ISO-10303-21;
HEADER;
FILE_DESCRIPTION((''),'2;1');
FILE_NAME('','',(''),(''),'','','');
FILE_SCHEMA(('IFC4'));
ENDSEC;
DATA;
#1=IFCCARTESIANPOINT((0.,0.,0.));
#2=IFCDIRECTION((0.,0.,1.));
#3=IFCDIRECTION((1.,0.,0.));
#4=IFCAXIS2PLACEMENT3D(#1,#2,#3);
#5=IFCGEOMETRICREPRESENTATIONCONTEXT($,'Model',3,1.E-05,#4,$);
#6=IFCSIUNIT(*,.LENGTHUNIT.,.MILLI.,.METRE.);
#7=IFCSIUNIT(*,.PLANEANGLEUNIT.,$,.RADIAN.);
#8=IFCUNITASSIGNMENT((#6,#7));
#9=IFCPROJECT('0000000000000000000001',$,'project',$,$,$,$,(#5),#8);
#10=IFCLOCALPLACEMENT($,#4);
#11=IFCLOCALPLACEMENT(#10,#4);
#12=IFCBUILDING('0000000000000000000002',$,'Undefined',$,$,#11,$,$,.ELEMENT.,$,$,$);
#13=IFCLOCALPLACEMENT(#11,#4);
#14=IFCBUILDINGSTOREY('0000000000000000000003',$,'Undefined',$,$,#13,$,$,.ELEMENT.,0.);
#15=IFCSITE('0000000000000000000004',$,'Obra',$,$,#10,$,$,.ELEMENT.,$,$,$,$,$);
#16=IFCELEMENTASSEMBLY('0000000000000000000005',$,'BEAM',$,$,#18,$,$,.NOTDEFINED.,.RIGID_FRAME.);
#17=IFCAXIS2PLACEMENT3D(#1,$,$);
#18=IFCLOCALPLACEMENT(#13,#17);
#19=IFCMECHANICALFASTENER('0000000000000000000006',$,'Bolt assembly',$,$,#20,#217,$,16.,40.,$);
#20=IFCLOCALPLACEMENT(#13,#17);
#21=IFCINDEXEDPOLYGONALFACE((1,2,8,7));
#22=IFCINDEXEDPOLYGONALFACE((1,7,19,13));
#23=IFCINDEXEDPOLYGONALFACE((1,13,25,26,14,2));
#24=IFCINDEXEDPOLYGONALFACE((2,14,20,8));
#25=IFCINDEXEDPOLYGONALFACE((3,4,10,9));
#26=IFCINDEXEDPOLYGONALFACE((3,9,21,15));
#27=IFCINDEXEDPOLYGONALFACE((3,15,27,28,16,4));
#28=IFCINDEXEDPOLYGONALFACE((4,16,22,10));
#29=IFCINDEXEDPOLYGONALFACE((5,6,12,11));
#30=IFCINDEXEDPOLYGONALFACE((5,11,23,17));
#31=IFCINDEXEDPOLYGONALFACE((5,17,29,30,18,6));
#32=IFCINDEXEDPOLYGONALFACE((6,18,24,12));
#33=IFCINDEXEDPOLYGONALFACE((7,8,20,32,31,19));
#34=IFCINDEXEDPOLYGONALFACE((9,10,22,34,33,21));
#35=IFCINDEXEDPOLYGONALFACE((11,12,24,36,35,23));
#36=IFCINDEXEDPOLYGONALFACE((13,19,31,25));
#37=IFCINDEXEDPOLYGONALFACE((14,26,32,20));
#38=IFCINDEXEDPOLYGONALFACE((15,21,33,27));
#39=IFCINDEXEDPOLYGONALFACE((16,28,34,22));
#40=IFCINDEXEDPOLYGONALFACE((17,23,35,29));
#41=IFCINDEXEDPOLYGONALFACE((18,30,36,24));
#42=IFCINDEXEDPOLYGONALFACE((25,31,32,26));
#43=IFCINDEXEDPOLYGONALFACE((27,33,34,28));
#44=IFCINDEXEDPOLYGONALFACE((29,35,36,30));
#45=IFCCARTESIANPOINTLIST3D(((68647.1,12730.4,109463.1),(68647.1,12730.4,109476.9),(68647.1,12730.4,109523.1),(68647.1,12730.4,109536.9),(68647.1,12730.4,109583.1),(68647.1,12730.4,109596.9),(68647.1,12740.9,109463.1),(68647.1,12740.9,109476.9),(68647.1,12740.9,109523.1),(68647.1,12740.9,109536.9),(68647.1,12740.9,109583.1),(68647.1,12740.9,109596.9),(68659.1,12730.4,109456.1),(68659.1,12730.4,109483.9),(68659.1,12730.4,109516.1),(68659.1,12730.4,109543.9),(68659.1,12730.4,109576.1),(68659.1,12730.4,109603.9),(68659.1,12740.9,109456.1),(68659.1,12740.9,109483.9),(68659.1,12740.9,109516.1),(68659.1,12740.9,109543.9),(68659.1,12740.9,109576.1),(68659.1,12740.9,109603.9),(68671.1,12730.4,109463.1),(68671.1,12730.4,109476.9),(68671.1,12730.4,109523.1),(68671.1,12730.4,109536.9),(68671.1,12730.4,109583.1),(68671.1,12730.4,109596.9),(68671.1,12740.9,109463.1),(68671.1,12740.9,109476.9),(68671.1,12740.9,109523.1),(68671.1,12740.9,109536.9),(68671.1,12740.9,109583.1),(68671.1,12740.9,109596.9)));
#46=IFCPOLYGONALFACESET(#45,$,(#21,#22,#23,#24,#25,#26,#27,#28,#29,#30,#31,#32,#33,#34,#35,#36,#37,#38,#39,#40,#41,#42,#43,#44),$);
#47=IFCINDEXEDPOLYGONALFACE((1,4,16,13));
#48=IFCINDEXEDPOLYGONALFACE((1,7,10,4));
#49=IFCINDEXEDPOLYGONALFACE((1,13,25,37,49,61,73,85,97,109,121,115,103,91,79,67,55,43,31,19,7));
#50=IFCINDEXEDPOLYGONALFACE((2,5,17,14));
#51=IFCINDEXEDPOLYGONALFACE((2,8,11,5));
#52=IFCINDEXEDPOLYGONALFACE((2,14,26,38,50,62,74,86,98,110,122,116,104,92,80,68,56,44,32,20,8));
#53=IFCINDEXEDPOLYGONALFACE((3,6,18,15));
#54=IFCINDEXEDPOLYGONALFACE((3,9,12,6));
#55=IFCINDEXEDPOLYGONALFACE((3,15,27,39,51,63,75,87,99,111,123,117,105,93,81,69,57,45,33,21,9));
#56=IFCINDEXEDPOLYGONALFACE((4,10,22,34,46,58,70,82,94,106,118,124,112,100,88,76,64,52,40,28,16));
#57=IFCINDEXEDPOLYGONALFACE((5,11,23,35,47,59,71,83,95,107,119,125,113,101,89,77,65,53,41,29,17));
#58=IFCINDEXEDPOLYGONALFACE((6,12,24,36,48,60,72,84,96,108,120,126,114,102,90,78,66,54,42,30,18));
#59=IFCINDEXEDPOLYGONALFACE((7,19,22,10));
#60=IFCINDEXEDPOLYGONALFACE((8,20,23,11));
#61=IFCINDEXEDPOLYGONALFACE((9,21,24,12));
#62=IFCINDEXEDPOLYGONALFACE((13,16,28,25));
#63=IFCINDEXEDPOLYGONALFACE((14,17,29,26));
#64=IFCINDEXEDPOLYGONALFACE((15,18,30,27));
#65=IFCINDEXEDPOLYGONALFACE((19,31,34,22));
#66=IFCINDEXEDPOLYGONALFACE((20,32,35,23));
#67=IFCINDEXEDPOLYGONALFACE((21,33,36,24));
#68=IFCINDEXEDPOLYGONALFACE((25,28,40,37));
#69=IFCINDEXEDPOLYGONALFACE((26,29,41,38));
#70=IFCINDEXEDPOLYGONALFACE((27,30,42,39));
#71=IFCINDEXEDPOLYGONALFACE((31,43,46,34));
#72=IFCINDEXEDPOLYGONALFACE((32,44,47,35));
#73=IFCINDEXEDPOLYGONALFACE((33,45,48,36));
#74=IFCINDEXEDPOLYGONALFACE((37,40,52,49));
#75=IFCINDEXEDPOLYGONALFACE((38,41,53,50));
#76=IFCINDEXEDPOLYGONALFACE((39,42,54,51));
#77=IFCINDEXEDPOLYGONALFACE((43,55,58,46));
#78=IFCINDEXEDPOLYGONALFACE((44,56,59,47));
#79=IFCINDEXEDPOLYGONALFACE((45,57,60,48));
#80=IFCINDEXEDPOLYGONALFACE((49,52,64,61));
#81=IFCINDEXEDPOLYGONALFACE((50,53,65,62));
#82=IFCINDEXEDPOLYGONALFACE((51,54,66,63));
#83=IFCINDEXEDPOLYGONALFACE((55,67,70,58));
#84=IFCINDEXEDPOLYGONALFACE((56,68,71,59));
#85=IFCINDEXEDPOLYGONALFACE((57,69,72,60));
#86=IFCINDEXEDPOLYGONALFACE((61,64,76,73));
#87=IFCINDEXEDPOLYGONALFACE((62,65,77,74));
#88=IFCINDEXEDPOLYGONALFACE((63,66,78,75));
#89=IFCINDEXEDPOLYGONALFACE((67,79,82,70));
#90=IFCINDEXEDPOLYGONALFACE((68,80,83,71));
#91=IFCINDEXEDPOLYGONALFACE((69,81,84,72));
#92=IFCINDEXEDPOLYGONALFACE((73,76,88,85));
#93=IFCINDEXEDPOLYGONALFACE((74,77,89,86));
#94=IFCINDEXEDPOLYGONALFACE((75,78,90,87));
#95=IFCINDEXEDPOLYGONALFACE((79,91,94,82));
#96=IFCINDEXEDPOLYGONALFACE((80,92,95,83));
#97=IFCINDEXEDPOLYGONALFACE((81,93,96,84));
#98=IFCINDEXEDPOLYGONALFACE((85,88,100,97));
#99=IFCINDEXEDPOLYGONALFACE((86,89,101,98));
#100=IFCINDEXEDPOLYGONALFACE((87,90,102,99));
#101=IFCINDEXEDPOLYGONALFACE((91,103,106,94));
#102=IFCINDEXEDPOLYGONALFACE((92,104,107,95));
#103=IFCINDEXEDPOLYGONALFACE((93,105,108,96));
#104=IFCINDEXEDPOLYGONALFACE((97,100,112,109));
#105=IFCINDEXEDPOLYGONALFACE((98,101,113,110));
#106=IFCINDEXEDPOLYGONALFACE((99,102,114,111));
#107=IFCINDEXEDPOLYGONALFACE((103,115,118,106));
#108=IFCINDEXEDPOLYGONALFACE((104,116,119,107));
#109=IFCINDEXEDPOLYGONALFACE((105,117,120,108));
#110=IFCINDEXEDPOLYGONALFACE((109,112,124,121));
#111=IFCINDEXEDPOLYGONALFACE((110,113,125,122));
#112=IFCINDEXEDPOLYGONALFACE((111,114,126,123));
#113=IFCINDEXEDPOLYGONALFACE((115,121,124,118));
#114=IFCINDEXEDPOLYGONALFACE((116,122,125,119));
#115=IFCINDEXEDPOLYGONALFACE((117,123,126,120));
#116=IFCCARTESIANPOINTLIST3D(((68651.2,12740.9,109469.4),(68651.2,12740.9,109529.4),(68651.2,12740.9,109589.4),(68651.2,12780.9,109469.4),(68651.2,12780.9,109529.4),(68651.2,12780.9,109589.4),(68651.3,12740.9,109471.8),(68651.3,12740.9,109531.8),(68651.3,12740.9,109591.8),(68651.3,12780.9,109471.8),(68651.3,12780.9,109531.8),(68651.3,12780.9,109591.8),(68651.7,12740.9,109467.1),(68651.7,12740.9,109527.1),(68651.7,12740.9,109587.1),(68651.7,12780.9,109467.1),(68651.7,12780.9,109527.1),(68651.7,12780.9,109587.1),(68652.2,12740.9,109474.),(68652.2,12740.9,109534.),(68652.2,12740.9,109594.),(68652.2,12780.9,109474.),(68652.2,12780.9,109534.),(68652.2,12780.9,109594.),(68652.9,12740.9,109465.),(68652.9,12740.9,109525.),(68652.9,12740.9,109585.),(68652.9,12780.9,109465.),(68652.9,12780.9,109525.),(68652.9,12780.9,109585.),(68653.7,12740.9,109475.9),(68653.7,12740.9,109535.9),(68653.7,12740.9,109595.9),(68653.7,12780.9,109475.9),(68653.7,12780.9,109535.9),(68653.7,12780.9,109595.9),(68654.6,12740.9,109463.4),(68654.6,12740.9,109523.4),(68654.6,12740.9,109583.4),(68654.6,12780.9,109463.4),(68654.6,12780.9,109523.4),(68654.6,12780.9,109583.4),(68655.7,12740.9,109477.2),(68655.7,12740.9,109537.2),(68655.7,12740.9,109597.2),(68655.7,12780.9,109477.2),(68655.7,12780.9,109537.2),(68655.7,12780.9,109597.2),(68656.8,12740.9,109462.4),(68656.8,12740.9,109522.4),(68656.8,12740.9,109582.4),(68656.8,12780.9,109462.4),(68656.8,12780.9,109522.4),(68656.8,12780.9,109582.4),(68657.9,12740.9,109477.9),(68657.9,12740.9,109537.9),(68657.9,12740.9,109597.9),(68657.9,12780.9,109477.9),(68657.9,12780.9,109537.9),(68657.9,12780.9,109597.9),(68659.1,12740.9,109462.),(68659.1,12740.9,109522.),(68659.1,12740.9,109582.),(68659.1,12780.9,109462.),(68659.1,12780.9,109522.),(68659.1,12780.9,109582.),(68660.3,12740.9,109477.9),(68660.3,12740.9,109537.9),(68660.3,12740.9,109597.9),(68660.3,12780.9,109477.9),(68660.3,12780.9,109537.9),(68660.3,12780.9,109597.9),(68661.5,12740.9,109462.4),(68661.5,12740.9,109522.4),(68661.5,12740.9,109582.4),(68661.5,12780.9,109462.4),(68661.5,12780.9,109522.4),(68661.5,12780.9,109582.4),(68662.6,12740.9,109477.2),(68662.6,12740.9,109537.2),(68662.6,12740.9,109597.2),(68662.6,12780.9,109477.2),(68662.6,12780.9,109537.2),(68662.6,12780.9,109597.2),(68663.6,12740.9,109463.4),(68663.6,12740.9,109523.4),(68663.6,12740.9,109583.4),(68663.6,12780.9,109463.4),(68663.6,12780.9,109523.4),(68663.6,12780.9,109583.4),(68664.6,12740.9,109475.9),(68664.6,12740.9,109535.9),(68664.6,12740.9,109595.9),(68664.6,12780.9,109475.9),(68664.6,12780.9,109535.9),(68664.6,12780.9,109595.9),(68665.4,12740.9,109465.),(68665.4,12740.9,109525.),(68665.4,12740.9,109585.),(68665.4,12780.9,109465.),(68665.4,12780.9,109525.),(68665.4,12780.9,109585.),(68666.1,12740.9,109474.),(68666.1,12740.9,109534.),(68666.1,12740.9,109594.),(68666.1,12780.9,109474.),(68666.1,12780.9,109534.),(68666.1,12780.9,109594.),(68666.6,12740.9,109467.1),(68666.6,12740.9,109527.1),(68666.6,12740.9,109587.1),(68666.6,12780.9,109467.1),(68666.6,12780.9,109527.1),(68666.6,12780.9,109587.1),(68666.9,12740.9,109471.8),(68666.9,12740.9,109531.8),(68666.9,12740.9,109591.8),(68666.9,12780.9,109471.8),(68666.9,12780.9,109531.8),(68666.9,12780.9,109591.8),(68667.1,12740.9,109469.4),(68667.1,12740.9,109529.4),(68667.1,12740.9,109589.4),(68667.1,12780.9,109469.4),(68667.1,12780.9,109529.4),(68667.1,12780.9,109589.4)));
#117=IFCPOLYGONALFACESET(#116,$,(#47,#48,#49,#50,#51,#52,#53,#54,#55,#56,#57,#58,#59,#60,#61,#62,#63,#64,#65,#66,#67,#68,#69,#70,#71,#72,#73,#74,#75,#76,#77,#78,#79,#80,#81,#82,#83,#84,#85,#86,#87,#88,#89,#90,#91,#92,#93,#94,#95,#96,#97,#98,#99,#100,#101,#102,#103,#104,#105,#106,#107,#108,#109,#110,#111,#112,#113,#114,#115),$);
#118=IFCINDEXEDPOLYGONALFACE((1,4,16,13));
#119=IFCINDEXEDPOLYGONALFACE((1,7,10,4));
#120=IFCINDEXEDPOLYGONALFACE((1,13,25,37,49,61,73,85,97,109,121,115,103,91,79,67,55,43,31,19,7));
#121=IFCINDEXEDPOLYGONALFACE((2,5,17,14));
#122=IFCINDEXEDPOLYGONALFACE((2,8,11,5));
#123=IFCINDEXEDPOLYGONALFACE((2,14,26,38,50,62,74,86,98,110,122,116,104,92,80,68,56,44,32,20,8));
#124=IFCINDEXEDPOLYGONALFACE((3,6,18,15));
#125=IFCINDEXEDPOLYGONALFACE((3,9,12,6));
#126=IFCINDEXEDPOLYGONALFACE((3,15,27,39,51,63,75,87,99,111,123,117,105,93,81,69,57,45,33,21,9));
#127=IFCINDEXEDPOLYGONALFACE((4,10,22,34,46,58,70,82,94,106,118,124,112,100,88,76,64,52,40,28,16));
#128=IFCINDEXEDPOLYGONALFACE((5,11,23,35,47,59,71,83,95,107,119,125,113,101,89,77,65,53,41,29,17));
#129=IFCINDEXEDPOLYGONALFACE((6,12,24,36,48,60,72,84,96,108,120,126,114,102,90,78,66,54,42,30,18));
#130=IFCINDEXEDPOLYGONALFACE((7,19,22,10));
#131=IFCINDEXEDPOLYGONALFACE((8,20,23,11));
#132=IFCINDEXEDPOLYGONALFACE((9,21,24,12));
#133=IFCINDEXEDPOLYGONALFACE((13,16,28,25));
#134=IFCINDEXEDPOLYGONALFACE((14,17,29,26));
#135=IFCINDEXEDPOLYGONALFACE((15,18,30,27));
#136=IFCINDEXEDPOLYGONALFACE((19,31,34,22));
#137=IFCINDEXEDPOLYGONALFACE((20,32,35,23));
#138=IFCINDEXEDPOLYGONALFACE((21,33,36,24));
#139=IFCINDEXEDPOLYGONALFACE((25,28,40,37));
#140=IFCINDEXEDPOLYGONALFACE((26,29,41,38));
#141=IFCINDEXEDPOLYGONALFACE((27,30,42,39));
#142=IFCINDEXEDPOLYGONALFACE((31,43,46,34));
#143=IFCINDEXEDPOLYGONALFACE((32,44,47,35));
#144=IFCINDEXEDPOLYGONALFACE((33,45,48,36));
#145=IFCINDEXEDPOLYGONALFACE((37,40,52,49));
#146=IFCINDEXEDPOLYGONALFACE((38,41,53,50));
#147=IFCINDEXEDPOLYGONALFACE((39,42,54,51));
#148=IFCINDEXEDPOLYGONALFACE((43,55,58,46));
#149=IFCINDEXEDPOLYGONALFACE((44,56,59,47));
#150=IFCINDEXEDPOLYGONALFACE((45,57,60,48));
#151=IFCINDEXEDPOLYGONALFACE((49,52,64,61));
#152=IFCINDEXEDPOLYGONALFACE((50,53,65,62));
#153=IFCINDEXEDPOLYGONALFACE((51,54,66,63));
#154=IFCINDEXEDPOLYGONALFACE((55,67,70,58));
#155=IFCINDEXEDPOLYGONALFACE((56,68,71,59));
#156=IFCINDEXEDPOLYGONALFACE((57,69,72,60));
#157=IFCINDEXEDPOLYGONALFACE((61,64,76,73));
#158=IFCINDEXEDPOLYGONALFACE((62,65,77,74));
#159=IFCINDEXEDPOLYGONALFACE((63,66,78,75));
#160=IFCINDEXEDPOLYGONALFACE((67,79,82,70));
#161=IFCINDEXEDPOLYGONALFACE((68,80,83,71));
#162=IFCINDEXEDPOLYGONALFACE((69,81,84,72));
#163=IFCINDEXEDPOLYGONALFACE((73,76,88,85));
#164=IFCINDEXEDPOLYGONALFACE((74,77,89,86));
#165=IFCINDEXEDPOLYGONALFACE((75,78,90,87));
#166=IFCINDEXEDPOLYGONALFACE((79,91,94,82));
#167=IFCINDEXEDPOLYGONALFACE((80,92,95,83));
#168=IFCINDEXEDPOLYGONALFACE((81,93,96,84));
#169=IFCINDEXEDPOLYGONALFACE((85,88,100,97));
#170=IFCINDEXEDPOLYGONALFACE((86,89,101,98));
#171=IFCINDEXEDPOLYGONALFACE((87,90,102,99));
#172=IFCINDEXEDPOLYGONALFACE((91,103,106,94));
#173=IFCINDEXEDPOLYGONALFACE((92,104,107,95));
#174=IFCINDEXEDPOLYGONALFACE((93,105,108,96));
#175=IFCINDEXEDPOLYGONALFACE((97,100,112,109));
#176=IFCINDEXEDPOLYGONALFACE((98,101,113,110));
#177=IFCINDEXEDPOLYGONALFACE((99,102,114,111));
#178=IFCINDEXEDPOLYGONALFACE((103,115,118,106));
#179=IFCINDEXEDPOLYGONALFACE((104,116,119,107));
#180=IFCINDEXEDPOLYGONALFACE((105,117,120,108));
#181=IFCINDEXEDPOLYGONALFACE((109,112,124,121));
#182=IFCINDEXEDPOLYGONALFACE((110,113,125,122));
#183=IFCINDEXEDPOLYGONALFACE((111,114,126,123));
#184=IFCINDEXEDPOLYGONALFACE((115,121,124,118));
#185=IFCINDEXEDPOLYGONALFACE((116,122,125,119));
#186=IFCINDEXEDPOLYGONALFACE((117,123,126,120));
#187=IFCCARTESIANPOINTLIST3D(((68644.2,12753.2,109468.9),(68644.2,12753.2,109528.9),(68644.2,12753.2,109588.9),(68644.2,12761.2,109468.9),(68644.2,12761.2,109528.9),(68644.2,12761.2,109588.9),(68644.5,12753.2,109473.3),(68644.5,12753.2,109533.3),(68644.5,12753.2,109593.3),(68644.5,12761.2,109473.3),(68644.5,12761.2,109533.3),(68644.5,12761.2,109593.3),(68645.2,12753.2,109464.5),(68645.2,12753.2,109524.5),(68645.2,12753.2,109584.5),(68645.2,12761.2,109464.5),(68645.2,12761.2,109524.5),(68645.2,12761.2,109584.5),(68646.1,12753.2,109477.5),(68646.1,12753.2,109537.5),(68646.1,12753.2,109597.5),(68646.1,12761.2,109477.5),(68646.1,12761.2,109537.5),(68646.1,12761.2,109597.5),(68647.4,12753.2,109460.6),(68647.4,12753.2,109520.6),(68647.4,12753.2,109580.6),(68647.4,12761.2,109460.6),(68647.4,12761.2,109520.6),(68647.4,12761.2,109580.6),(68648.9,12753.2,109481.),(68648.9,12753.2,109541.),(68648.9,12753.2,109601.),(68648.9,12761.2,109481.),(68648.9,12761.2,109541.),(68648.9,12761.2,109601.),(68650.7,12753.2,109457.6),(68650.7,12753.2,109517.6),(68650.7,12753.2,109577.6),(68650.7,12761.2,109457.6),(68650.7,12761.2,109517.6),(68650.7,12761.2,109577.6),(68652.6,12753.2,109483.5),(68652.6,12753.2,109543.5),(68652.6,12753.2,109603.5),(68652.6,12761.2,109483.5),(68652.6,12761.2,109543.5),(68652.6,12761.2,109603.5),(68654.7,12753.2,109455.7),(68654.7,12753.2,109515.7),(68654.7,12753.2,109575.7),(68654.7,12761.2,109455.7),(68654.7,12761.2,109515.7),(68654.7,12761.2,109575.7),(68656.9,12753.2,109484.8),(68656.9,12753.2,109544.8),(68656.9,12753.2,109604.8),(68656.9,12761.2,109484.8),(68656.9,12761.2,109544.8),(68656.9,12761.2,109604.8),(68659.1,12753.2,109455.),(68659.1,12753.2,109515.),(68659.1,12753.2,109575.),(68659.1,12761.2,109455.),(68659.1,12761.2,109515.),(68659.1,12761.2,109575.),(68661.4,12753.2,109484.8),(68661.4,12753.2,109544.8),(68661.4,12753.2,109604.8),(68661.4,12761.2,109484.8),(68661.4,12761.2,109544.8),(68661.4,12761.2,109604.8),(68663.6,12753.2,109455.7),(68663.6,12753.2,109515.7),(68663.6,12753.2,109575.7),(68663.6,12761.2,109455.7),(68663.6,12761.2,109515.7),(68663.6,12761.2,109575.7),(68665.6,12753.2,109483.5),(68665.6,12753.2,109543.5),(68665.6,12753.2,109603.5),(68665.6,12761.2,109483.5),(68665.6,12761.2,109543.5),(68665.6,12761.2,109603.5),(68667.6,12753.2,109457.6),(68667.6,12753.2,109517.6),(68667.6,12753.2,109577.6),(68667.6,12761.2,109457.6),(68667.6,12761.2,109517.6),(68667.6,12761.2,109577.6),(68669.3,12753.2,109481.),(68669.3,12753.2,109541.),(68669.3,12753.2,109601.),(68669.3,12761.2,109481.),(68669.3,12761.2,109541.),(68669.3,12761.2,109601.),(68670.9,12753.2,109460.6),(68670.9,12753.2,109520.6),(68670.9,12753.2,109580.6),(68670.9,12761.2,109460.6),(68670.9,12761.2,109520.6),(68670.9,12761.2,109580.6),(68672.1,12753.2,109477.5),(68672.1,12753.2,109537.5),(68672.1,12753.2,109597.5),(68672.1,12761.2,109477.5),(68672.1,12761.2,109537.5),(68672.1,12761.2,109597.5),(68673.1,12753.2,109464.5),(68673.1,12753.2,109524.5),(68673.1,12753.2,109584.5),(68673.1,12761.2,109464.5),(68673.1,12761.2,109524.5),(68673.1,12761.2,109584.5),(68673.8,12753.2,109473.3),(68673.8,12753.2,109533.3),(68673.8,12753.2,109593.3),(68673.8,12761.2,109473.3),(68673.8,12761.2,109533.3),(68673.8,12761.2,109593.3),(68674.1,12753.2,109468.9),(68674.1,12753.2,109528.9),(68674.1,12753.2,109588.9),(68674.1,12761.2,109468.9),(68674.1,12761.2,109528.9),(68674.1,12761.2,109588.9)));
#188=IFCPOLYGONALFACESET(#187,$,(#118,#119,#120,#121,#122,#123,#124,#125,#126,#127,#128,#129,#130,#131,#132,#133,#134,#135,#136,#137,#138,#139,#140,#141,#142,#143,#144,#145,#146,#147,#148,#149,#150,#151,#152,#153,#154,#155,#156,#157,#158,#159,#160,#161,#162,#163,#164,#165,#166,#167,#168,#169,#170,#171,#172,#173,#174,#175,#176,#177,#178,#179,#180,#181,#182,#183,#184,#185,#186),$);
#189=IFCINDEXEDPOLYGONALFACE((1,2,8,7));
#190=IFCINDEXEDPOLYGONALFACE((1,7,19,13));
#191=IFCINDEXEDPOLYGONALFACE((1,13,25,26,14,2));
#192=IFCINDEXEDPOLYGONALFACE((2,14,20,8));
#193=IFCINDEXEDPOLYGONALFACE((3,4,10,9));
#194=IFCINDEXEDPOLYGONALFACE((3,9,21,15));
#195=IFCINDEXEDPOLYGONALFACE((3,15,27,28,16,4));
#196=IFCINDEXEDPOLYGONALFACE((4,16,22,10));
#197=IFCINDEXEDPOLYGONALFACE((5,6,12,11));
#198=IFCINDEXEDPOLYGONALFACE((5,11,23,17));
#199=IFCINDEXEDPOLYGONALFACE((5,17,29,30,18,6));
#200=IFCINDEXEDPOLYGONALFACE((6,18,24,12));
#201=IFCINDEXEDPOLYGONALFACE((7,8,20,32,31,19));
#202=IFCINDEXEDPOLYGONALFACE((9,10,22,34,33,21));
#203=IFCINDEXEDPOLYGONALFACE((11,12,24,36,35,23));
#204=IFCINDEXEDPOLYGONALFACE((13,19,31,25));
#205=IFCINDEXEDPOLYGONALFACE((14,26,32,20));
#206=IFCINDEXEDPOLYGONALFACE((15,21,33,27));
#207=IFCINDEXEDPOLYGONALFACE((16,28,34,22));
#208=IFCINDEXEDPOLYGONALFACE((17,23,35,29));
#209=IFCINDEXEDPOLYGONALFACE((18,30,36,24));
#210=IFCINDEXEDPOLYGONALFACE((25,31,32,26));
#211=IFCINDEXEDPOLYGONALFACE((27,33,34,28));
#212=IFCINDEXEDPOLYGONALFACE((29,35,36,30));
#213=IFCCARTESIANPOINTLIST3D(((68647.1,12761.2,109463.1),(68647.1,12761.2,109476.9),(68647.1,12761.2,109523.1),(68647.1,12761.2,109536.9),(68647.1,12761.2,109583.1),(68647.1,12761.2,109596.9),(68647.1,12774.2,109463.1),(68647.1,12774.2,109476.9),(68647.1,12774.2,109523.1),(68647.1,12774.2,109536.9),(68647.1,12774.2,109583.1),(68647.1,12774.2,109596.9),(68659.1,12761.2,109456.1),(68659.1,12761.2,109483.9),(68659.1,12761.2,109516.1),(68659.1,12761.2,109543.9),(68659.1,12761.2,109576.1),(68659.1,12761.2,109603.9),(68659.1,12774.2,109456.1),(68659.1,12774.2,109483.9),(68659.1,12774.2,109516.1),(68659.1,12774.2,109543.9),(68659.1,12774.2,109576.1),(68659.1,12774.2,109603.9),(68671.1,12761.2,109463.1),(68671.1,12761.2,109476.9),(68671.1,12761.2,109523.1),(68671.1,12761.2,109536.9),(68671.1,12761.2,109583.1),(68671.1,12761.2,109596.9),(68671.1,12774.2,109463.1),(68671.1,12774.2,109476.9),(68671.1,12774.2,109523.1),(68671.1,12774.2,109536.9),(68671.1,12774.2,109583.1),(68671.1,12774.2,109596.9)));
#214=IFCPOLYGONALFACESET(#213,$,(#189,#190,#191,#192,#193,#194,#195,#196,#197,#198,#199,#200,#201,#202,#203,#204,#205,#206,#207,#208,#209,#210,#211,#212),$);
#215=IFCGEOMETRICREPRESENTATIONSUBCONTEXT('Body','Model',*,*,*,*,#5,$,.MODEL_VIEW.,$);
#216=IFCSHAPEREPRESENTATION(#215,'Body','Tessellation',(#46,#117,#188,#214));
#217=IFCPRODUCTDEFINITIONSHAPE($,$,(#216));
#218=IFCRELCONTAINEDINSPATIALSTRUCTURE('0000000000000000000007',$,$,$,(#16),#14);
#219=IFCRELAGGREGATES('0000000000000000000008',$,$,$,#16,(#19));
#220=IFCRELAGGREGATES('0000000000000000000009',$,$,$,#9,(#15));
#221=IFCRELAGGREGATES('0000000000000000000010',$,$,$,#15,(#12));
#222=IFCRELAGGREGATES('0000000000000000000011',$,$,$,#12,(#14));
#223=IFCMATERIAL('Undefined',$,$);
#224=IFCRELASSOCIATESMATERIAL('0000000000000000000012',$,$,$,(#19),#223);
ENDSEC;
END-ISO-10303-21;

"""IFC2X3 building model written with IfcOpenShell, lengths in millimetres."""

from ifc_helpers import new_model, si_unit, frame, origin_with_axes, origin_2d_with_axis, place, context, subcontext, project, spatial, polyline, circle, outline, extrude, source, transform, mapped, material, element, aggregate, save


model = new_model("IFC2X3")

# Units and contexts
model_context = context("Model", 3, precision=1e-05, world=origin_with_axes())
body_context = subcontext(model_context, "Body", "Model", "MODEL_VIEW")
ifc_project = project(units=[si_unit("LENGTHUNIT", "METRE", prefix="MILLI"), si_unit("PLANEANGLEUNIT", "RADIAN")], contexts=[model_context])

# Site, building, storey
site_placement = place(None, origin_with_axes())
site = spatial("IfcSite", under=ifc_project, at=site_placement, Name="Obra", CompositionType="ELEMENT")
building_placement = place(site_placement, origin_with_axes())
building = spatial("IfcBuilding", under=site, at=building_placement, Name="Undefined", CompositionType="ELEMENT")
storey_placement = place(building_placement, origin_with_axes())
storey = spatial("IfcBuildingStorey", under=building, at=storey_placement, Name="Undefined", CompositionType="ELEMENT", Elevation=0.0)

# Element assembly
assembly_1_placement = place(storey_placement, origin_with_axes())
assembly_1 = element("IfcElementAssembly", 1, at=assembly_1_placement, inside=storey, Name="BEAM", AssemblyPlace="NOTDEFINED", PredefinedType="RIGID_FRAME")

# Shared definitions
ifc_material_1 = material(Name="Undefined")

# Shared definitions
shared_shape_1 = source(origin_with_axes(), body_context, "Body", "SweptSolid", [
    extrude(outline(polyline([(13.9, 0.0), (6.9, 12.0), (-6.9, 12.0), (-13.9, 0.0), (-6.9, -12.0), (6.9, -12.0), (13.9, 0.0)])), frame((0.0, -19.7, 0.0), z_axis=(0.0, 1.0, 0.0), x_axis=(1.0, 0.0, 0.0)), (0.0, 0.0, 1.0), 10.6),
    extrude(circle(Radius=8.0, at=origin_2d_with_axis()), frame((0.0, -9.1, 0.0), z_axis=(0.0, 1.0, 0.0), x_axis=(1.0, 0.0, 0.0)), (0.0, 0.0, 1.0), 40.0),
    extrude(circle(Radius=15.0, at=origin_2d_with_axis()), frame((0.0, 3.1, 0.0), z_axis=(0.0, 1.0, 0.0), x_axis=(1.0, 0.0, 0.0)), (0.0, 0.0, 1.0), 8.0),
    extrude(outline(polyline([(13.9, 0.0), (6.9, 12.0), (-6.9, 12.0), (-13.9, 0.0), (-6.9, -12.0), (6.9, -12.0), (13.9, 0.0)])), frame((0.0, 11.1, 0.0), z_axis=(0.0, 1.0, 0.0), x_axis=(1.0, 0.0, 0.0)), (0.0, 0.0, 1.0), 13.0),
])

# Mechanical fastener
mechanical_fastener_1_placement = place(assembly_1_placement, frame((68609.1, 12750.0, 109650.0), z_axis=(1.0, -0.000126, 0.0), x_axis=(0.0, 0.0, -1.0)))
mechanical_fastener_1 = element("IfcMechanicalFastener", 2, at=mechanical_fastener_1_placement, material=ifc_material_1, Name="Bolt assembly", NominalDiameter=16.0, NominalLength=40.0, context=body_context, shape_type="MappedRepresentation", body=[
    mapped(shared_shape_1, transform((60.0, 0.0, 50.0))),
    mapped(shared_shape_1, transform((120.0, 0.0, 50.0))),
    mapped(shared_shape_1, transform((180.0, 0.0, 50.0))),
])
aggregate(assembly_1, [mechanical_fastener_1])

save(model, "model.ifc")
